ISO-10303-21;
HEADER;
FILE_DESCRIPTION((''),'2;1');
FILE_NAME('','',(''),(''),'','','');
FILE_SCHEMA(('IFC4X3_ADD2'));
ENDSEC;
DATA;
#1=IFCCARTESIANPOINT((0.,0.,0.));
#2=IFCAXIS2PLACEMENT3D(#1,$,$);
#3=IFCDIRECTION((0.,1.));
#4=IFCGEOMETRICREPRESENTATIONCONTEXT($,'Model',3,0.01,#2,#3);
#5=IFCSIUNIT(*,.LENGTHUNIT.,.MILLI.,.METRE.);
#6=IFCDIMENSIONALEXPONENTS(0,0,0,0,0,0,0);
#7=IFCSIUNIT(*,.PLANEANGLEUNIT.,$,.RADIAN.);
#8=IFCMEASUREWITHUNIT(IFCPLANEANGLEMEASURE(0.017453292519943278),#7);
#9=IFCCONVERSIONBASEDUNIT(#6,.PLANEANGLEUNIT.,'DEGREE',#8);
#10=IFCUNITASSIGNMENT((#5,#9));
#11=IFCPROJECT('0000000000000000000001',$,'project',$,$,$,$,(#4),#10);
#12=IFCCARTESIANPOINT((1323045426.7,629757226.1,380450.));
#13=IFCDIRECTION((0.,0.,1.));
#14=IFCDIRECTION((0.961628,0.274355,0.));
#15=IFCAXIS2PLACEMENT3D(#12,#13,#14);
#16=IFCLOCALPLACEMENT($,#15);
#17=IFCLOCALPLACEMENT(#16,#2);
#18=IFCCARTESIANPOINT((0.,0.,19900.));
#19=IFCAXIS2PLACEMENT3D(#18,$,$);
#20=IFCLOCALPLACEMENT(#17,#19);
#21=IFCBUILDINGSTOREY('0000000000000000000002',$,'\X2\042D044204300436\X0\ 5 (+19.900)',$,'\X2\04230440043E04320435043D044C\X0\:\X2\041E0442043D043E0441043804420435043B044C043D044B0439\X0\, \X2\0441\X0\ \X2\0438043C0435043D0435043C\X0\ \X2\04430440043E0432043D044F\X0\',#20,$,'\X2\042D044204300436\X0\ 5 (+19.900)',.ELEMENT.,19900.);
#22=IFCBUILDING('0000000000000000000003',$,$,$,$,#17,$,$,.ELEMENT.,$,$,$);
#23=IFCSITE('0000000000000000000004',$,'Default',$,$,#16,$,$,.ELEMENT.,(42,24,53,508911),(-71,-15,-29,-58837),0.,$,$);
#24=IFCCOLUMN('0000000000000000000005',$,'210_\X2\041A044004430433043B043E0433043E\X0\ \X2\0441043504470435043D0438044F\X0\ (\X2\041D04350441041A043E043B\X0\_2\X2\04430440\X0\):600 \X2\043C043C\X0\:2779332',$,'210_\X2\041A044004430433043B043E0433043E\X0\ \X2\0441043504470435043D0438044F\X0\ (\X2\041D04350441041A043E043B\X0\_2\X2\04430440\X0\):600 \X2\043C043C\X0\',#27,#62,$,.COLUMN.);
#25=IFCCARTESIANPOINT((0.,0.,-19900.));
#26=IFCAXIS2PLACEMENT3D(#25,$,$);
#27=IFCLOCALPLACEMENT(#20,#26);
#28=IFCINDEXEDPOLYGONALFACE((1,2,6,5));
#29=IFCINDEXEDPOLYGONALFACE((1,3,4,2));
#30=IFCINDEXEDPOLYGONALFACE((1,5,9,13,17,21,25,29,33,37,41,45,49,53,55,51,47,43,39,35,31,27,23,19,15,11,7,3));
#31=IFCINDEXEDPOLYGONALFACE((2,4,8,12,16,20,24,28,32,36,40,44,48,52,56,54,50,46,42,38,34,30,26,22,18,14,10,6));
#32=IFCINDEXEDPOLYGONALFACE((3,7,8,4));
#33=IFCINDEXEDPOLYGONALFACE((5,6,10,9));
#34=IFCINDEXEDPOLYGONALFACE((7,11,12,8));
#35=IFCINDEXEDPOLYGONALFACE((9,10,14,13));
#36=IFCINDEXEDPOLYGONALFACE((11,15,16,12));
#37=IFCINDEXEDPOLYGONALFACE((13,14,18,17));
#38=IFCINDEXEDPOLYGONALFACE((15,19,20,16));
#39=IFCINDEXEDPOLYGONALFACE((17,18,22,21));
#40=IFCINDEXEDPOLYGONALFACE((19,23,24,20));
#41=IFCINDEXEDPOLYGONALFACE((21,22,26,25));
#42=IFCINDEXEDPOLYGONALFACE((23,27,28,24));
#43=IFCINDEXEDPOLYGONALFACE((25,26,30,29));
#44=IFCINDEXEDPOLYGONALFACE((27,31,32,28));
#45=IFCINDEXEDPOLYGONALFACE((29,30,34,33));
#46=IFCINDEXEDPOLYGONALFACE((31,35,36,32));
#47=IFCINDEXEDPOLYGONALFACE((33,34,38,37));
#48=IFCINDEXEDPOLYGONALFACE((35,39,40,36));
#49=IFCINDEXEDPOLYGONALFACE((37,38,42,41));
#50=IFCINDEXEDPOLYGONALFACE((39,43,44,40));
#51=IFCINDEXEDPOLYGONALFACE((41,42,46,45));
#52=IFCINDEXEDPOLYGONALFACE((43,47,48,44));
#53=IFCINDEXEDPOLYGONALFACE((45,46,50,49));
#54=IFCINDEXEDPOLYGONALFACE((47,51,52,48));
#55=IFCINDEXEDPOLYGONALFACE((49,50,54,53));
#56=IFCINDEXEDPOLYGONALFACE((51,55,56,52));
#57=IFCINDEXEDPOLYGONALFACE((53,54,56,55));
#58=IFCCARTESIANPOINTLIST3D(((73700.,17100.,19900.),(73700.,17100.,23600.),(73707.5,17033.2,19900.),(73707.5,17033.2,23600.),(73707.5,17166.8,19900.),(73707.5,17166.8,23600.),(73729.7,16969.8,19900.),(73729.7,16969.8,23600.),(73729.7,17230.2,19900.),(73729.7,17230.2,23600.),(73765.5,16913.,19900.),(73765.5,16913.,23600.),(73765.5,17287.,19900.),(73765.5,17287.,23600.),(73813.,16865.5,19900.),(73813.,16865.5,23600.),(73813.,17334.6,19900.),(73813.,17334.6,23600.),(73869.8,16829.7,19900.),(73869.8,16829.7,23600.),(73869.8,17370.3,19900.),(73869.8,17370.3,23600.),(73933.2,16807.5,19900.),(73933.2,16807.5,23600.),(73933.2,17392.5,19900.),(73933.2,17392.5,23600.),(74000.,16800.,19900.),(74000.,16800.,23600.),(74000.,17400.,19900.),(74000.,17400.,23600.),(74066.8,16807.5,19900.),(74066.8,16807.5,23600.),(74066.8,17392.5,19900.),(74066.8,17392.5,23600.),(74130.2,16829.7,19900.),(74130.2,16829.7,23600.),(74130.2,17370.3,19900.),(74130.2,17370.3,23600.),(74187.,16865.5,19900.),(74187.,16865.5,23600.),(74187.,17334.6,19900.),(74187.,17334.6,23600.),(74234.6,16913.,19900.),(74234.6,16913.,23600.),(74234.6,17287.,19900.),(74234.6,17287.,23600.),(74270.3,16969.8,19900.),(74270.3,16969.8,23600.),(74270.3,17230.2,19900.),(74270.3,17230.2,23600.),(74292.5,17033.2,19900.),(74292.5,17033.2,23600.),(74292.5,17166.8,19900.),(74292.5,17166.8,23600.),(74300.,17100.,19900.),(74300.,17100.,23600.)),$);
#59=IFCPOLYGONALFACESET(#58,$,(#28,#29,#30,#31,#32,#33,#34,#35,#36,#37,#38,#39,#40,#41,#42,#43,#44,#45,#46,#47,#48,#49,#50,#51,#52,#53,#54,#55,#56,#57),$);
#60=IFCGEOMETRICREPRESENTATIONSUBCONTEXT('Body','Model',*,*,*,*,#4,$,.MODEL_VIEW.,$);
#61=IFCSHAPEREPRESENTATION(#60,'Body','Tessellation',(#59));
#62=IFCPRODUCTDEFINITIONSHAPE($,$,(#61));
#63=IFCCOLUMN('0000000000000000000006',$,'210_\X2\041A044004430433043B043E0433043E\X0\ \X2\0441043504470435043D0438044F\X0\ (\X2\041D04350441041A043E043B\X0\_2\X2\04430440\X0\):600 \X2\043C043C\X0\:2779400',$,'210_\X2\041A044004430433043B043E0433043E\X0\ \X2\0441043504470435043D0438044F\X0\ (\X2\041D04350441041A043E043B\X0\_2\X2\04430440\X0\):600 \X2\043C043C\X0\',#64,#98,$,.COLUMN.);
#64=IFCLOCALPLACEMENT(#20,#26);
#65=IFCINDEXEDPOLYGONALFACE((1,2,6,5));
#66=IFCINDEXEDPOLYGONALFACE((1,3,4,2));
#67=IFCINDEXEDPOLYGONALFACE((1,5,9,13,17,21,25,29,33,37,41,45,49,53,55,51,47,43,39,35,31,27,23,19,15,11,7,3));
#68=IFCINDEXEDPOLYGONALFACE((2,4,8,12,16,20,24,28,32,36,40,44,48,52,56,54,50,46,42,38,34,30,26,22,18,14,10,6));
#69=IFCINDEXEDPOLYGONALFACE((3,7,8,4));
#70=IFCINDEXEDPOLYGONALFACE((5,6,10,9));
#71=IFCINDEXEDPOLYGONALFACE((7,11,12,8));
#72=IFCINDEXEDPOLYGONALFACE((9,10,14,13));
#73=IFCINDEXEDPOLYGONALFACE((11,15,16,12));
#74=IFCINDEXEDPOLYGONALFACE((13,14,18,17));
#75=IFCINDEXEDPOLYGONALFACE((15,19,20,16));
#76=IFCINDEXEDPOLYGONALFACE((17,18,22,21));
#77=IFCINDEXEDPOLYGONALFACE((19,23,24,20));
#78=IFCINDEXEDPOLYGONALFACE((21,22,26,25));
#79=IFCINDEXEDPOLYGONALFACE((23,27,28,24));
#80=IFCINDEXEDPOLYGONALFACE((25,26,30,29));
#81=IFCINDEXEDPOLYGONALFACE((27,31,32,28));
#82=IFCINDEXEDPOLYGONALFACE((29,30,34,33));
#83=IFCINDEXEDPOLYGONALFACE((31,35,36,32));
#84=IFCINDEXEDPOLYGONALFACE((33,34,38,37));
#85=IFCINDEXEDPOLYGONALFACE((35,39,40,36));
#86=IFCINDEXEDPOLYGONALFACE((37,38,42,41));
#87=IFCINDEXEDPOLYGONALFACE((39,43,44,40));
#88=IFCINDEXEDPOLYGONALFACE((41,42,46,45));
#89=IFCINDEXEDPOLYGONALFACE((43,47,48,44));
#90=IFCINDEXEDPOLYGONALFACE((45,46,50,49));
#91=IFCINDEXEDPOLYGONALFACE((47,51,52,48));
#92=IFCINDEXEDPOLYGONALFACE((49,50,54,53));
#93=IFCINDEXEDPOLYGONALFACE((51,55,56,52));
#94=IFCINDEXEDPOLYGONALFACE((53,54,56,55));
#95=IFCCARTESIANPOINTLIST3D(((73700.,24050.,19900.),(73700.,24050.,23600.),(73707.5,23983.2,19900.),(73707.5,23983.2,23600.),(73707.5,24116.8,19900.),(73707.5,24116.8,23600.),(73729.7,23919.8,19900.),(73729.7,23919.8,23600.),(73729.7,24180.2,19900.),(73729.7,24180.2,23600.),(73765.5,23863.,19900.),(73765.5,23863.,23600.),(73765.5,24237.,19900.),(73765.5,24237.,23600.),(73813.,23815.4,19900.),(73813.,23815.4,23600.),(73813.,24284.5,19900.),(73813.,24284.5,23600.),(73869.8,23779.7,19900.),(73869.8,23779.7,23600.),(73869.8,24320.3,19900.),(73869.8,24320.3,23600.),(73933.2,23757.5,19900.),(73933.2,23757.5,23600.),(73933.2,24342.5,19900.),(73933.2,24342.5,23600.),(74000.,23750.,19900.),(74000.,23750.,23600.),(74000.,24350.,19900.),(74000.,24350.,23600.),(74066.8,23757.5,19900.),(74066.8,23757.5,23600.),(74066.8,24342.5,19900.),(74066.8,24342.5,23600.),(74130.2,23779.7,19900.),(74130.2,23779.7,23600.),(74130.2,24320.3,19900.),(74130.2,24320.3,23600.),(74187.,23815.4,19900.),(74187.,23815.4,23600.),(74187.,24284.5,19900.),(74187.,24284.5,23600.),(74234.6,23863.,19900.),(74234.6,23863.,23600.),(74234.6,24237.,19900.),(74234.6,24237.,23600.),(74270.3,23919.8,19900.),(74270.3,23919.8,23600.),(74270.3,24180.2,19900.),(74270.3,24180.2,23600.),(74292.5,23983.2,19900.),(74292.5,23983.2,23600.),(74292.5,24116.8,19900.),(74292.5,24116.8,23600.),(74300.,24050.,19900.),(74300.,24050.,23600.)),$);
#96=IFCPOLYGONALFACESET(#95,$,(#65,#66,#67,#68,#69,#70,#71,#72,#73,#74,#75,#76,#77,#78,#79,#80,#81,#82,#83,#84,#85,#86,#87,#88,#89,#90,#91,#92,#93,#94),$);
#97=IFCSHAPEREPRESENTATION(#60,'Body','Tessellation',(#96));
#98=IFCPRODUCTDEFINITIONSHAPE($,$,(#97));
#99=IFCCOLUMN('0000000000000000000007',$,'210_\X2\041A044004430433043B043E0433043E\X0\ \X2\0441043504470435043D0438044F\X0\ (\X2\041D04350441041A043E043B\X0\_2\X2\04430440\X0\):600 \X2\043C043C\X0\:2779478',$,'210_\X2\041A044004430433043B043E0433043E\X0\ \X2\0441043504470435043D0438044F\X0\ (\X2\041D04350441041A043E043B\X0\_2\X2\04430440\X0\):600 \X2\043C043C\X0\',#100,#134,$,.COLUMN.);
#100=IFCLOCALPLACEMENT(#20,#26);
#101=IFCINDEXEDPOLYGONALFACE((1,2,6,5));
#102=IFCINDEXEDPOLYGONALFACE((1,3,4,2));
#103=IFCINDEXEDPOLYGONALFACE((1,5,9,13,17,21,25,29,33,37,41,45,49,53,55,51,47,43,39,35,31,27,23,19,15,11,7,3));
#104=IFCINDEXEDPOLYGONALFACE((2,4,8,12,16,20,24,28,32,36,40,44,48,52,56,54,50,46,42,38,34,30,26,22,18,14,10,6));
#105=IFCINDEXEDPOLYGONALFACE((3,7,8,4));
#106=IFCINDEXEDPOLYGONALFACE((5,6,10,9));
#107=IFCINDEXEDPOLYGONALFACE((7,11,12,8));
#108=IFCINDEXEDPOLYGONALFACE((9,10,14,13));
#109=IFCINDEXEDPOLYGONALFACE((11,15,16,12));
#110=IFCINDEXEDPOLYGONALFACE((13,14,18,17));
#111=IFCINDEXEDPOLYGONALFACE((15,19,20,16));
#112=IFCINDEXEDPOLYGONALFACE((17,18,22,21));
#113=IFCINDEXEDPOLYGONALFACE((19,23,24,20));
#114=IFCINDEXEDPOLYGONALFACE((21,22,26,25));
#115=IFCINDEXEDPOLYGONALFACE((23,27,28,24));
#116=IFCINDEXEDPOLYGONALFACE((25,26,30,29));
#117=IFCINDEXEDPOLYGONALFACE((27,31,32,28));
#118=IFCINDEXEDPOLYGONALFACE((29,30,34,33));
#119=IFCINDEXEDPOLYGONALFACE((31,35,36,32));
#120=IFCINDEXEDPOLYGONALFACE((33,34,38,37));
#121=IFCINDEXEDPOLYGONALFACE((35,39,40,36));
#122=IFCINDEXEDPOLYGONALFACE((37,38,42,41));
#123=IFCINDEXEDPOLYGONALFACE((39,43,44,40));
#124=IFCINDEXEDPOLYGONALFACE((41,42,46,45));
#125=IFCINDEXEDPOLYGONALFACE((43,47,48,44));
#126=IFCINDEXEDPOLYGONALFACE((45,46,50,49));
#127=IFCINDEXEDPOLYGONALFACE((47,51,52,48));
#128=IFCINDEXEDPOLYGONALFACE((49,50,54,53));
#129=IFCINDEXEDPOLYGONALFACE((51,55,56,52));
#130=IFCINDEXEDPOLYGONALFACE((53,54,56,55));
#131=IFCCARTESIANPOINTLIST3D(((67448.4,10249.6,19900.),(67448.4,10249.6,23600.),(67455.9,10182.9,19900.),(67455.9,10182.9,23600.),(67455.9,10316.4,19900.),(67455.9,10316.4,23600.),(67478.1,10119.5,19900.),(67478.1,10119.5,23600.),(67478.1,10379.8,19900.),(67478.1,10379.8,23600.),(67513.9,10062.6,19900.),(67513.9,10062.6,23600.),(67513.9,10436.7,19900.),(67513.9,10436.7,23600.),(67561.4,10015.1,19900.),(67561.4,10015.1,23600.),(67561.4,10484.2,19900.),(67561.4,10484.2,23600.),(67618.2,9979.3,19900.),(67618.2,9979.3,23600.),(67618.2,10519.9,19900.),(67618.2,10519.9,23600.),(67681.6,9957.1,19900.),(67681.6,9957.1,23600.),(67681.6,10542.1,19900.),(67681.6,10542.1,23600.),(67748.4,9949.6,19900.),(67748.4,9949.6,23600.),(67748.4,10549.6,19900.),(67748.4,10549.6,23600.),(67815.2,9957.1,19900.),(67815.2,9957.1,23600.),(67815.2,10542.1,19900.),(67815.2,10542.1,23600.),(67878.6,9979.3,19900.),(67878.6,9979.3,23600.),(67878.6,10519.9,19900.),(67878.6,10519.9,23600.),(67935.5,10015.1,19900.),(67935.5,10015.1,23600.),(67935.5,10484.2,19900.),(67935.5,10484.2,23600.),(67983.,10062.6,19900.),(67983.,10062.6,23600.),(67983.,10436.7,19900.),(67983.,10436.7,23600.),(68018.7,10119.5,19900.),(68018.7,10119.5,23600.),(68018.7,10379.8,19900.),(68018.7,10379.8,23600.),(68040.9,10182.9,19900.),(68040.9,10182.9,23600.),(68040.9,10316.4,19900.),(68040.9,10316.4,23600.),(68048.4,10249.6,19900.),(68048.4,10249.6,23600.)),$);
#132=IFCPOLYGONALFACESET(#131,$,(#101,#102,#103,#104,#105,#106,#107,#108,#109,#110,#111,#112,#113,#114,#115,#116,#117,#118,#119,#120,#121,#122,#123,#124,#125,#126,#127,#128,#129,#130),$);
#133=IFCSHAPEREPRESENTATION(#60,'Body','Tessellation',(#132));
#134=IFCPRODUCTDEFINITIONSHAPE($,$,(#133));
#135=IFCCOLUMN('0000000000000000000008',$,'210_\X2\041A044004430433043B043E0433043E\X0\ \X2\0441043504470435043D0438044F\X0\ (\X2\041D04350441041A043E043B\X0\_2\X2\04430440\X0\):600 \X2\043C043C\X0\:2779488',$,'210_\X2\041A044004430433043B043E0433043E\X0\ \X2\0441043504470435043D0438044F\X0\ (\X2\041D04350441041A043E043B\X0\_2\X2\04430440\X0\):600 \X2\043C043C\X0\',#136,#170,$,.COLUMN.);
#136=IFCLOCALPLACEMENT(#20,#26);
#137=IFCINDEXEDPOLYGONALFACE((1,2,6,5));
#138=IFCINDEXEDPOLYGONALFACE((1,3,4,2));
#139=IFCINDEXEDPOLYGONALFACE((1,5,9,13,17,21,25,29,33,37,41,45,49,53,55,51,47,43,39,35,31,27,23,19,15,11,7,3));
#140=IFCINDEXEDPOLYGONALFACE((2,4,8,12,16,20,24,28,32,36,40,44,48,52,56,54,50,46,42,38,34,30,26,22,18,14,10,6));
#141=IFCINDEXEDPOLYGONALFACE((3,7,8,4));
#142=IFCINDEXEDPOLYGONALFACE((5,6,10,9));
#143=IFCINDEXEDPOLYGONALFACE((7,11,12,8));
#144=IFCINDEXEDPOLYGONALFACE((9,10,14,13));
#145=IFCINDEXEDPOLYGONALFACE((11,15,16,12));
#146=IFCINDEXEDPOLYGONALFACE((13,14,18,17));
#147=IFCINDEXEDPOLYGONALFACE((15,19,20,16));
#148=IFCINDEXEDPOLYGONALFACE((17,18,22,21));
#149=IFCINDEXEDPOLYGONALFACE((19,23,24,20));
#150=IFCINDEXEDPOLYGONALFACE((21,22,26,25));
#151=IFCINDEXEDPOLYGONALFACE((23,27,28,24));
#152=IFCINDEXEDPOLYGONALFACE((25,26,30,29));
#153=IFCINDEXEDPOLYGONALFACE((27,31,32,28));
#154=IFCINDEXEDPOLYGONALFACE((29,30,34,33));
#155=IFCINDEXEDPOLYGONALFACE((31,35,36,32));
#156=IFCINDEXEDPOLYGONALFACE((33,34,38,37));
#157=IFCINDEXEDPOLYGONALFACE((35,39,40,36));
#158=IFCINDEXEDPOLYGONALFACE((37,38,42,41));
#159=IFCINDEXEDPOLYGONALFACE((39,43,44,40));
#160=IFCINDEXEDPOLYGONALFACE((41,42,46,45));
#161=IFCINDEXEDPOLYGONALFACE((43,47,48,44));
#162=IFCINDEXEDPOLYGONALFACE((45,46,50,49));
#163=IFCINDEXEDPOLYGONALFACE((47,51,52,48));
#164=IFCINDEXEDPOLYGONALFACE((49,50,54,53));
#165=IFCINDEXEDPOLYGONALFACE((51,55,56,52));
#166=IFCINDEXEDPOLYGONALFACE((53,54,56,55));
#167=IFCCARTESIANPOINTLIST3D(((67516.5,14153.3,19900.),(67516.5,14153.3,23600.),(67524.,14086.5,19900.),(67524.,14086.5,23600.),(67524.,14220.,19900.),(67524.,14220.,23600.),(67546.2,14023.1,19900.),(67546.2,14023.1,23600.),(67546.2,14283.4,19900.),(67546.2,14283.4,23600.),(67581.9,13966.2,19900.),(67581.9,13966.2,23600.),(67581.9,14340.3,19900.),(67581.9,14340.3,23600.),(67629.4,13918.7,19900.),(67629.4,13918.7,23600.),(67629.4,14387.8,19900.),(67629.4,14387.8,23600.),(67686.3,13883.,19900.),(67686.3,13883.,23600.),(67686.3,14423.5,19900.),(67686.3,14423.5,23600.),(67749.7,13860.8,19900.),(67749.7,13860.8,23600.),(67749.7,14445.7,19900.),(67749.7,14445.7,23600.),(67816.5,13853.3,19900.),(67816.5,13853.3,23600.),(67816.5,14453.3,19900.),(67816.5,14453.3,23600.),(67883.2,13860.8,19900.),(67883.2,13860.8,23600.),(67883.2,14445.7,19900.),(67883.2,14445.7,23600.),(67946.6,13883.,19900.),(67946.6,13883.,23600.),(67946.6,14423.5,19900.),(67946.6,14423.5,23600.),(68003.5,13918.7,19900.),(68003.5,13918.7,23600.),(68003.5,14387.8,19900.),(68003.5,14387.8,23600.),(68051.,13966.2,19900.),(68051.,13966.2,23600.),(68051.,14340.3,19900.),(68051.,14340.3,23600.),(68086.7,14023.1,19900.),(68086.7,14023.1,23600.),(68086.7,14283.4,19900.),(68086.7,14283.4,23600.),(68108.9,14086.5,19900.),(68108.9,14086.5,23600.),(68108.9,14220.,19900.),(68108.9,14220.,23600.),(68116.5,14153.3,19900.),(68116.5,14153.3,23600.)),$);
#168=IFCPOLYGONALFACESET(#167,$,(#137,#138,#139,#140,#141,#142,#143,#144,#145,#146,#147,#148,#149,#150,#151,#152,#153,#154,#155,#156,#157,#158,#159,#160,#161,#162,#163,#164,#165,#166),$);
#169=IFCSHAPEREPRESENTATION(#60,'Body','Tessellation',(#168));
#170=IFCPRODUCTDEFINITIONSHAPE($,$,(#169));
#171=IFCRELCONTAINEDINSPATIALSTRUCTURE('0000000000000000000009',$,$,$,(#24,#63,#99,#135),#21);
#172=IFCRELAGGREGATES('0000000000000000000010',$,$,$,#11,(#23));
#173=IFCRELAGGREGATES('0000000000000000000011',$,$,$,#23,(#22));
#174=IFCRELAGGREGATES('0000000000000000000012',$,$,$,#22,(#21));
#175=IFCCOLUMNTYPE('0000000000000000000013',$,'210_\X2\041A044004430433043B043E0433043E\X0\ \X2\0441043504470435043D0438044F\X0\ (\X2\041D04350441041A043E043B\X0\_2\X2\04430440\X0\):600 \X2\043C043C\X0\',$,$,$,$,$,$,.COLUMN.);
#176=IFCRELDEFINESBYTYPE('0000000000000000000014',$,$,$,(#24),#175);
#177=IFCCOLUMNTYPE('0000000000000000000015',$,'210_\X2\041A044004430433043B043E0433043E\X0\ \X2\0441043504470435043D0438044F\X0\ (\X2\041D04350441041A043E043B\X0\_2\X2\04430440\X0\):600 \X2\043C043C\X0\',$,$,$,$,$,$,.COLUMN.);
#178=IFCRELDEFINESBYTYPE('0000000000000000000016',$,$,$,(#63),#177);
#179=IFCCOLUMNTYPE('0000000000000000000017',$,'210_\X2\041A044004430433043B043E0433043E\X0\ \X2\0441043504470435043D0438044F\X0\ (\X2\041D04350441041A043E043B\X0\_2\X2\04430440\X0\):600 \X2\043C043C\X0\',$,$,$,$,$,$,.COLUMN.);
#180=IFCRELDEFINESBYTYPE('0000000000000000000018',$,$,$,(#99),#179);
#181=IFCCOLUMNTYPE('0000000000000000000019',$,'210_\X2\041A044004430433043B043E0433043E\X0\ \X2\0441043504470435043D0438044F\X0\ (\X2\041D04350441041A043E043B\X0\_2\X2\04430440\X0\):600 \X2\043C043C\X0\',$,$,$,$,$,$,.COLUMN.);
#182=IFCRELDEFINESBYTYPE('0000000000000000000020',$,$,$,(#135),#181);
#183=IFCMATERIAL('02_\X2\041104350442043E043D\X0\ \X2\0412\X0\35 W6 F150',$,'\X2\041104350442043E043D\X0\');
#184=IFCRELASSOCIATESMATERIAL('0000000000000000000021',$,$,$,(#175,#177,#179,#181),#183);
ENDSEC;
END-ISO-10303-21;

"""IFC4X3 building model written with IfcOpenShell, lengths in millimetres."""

from ifc_helpers import new_model, entity, si_unit, converted_unit, direction, frame, origin, origin_2d_with_axis, place, context, subcontext, project, spatial, circle, extrude, source, transform, mapped, material, material_profile, profile_set, type_object, type_shapes, element, save


model = new_model("IFC4X3")

# Units and contexts
model_context = context("Model", 3, precision=0.01, world=origin(), true_north=direction((0.0, 1.0)))
body_context = subcontext(model_context, "Body", "Model", "MODEL_VIEW")
ifc_project = project(units=[si_unit("LENGTHUNIT", "METRE", prefix="MILLI"), converted_unit("PLANEANGLEUNIT", "DEGREE", entity("IfcPlaneAngleMeasure", 0.017453292519943278), si_unit("PLANEANGLEUNIT", "RADIAN"), dimensions=[0, 0, 0, 0, 0, 0, 0])], contexts=[model_context])

# Site, building, storey
site_placement = place(None, frame((1323045426.7, 629757226.1, 380450.0), z_axis=(0.0, 0.0, 1.0), x_axis=(0.961628, 0.274355, 0.0)))
site = spatial("IfcSite", under=ifc_project, at=site_placement, Name="Default", CompositionType="ELEMENT", RefLatitude=(42, 24, 53, 508911), RefLongitude=(-71, -15, -29, -58837), RefElevation=0.0)
building_placement = place(site_placement, origin())
building = spatial("IfcBuilding", under=site, at=building_placement, CompositionType="ELEMENT")
storey_placement = place(building_placement, frame((0.0, 0.0, 19900.0)))
storey = spatial("IfcBuildingStorey", under=building, at=storey_placement, Name="Этаж 5 (+19.900)", ObjectType="Уровень:Относительный, с именем уровня", LongName="Этаж 5 (+19.900)", CompositionType="ELEMENT", Elevation=19900.0)

# Columns
ifc_material = material(Name="02_Бетон В35 W6 F150", Category="Бетон")
ifc_material_profile = material_profile(ifc_material, circle(Radius=300.0, at=origin_2d_with_axis()), Name="600 мм")
ifc_profile_set = profile_set([ifc_material_profile], Name="600 мм")
column_type_1 = type_object("IfcColumnType", Name="210_Круглого сечения (НесКол_2ур):600 мм", PredefinedType="COLUMN", material=ifc_profile_set)
shared_shape_1 = source(origin(), body_context, "Body", "SweptSolid", [
    extrude(circle(Radius=300.0, at=origin_2d_with_axis()), frame((74000.0, 17100.0, 19900.0)), (0.0, 0.0, 1.0), 3700.0),
])
type_shapes(column_type_1, [shared_shape_1])
column_1_placement = place(storey_placement, frame((0.0, 0.0, -19900.0)))
element("IfcColumn", 1, at=column_1_placement, inside=storey, type_object=column_type_1, Name="210_Круглого сечения (НесКол_2ур):600 мм:2779332", ObjectType="210_Круглого сечения (НесКол_2ур):600 мм", PredefinedType="COLUMN", context=body_context, shape_type="MappedRepresentation", body=[
    mapped(shared_shape_1, transform((0.0, 0.0, 0.0), scale=1.0)),
])
column_type_2 = type_object("IfcColumnType", Name="210_Круглого сечения (НесКол_2ур):600 мм", PredefinedType="COLUMN", material=ifc_profile_set)
shared_shape_2 = source(origin(), body_context, "Body", "SweptSolid", [
    extrude(circle(Radius=300.0, at=origin_2d_with_axis()), frame((74000.0, 24050.0, 19900.0)), (0.0, 0.0, 1.0), 3700.0),
])
type_shapes(column_type_2, [shared_shape_2])
column_2_placement = place(storey_placement, frame((0.0, 0.0, -19900.0)))
element("IfcColumn", 2, at=column_2_placement, inside=storey, type_object=column_type_2, Name="210_Круглого сечения (НесКол_2ур):600 мм:2779400", ObjectType="210_Круглого сечения (НесКол_2ур):600 мм", PredefinedType="COLUMN", context=body_context, shape_type="MappedRepresentation", body=[
    mapped(shared_shape_2, transform((0.0, 0.0, 0.0), scale=1.0)),
])
column_type_3 = type_object("IfcColumnType", Name="210_Круглого сечения (НесКол_2ур):600 мм", PredefinedType="COLUMN", material=ifc_profile_set)
shared_shape_3 = source(origin(), body_context, "Body", "SweptSolid", [
    extrude(circle(Radius=300.0, at=origin_2d_with_axis()), frame((67748.4, 10249.6, 19900.0)), (0.0, 0.0, 1.0), 3700.0),
])
type_shapes(column_type_3, [shared_shape_3])
column_3_placement = place(storey_placement, frame((0.0, 0.0, -19900.0)))
element("IfcColumn", 3, at=column_3_placement, inside=storey, type_object=column_type_3, Name="210_Круглого сечения (НесКол_2ур):600 мм:2779478", ObjectType="210_Круглого сечения (НесКол_2ур):600 мм", PredefinedType="COLUMN", context=body_context, shape_type="MappedRepresentation", body=[
    mapped(shared_shape_3, transform((0.0, 0.0, 0.0), scale=1.0)),
])
column_type_4 = type_object("IfcColumnType", Name="210_Круглого сечения (НесКол_2ур):600 мм", PredefinedType="COLUMN", material=ifc_profile_set)
shared_shape_4 = source(origin(), body_context, "Body", "SweptSolid", [
    extrude(circle(Radius=300.0, at=origin_2d_with_axis()), frame((67816.5, 14153.3, 19900.0)), (0.0, 0.0, 1.0), 3700.0),
])
type_shapes(column_type_4, [shared_shape_4])
column_4_placement = place(storey_placement, frame((0.0, 0.0, -19900.0)))
element("IfcColumn", 4, at=column_4_placement, inside=storey, type_object=column_type_4, Name="210_Круглого сечения (НесКол_2ур):600 мм:2779488", ObjectType="210_Круглого сечения (НесКол_2ур):600 мм", PredefinedType="COLUMN", context=body_context, shape_type="MappedRepresentation", body=[
    mapped(shared_shape_4, transform((0.0, 0.0, 0.0), scale=1.0)),
])

save(model, "model.ifc")
